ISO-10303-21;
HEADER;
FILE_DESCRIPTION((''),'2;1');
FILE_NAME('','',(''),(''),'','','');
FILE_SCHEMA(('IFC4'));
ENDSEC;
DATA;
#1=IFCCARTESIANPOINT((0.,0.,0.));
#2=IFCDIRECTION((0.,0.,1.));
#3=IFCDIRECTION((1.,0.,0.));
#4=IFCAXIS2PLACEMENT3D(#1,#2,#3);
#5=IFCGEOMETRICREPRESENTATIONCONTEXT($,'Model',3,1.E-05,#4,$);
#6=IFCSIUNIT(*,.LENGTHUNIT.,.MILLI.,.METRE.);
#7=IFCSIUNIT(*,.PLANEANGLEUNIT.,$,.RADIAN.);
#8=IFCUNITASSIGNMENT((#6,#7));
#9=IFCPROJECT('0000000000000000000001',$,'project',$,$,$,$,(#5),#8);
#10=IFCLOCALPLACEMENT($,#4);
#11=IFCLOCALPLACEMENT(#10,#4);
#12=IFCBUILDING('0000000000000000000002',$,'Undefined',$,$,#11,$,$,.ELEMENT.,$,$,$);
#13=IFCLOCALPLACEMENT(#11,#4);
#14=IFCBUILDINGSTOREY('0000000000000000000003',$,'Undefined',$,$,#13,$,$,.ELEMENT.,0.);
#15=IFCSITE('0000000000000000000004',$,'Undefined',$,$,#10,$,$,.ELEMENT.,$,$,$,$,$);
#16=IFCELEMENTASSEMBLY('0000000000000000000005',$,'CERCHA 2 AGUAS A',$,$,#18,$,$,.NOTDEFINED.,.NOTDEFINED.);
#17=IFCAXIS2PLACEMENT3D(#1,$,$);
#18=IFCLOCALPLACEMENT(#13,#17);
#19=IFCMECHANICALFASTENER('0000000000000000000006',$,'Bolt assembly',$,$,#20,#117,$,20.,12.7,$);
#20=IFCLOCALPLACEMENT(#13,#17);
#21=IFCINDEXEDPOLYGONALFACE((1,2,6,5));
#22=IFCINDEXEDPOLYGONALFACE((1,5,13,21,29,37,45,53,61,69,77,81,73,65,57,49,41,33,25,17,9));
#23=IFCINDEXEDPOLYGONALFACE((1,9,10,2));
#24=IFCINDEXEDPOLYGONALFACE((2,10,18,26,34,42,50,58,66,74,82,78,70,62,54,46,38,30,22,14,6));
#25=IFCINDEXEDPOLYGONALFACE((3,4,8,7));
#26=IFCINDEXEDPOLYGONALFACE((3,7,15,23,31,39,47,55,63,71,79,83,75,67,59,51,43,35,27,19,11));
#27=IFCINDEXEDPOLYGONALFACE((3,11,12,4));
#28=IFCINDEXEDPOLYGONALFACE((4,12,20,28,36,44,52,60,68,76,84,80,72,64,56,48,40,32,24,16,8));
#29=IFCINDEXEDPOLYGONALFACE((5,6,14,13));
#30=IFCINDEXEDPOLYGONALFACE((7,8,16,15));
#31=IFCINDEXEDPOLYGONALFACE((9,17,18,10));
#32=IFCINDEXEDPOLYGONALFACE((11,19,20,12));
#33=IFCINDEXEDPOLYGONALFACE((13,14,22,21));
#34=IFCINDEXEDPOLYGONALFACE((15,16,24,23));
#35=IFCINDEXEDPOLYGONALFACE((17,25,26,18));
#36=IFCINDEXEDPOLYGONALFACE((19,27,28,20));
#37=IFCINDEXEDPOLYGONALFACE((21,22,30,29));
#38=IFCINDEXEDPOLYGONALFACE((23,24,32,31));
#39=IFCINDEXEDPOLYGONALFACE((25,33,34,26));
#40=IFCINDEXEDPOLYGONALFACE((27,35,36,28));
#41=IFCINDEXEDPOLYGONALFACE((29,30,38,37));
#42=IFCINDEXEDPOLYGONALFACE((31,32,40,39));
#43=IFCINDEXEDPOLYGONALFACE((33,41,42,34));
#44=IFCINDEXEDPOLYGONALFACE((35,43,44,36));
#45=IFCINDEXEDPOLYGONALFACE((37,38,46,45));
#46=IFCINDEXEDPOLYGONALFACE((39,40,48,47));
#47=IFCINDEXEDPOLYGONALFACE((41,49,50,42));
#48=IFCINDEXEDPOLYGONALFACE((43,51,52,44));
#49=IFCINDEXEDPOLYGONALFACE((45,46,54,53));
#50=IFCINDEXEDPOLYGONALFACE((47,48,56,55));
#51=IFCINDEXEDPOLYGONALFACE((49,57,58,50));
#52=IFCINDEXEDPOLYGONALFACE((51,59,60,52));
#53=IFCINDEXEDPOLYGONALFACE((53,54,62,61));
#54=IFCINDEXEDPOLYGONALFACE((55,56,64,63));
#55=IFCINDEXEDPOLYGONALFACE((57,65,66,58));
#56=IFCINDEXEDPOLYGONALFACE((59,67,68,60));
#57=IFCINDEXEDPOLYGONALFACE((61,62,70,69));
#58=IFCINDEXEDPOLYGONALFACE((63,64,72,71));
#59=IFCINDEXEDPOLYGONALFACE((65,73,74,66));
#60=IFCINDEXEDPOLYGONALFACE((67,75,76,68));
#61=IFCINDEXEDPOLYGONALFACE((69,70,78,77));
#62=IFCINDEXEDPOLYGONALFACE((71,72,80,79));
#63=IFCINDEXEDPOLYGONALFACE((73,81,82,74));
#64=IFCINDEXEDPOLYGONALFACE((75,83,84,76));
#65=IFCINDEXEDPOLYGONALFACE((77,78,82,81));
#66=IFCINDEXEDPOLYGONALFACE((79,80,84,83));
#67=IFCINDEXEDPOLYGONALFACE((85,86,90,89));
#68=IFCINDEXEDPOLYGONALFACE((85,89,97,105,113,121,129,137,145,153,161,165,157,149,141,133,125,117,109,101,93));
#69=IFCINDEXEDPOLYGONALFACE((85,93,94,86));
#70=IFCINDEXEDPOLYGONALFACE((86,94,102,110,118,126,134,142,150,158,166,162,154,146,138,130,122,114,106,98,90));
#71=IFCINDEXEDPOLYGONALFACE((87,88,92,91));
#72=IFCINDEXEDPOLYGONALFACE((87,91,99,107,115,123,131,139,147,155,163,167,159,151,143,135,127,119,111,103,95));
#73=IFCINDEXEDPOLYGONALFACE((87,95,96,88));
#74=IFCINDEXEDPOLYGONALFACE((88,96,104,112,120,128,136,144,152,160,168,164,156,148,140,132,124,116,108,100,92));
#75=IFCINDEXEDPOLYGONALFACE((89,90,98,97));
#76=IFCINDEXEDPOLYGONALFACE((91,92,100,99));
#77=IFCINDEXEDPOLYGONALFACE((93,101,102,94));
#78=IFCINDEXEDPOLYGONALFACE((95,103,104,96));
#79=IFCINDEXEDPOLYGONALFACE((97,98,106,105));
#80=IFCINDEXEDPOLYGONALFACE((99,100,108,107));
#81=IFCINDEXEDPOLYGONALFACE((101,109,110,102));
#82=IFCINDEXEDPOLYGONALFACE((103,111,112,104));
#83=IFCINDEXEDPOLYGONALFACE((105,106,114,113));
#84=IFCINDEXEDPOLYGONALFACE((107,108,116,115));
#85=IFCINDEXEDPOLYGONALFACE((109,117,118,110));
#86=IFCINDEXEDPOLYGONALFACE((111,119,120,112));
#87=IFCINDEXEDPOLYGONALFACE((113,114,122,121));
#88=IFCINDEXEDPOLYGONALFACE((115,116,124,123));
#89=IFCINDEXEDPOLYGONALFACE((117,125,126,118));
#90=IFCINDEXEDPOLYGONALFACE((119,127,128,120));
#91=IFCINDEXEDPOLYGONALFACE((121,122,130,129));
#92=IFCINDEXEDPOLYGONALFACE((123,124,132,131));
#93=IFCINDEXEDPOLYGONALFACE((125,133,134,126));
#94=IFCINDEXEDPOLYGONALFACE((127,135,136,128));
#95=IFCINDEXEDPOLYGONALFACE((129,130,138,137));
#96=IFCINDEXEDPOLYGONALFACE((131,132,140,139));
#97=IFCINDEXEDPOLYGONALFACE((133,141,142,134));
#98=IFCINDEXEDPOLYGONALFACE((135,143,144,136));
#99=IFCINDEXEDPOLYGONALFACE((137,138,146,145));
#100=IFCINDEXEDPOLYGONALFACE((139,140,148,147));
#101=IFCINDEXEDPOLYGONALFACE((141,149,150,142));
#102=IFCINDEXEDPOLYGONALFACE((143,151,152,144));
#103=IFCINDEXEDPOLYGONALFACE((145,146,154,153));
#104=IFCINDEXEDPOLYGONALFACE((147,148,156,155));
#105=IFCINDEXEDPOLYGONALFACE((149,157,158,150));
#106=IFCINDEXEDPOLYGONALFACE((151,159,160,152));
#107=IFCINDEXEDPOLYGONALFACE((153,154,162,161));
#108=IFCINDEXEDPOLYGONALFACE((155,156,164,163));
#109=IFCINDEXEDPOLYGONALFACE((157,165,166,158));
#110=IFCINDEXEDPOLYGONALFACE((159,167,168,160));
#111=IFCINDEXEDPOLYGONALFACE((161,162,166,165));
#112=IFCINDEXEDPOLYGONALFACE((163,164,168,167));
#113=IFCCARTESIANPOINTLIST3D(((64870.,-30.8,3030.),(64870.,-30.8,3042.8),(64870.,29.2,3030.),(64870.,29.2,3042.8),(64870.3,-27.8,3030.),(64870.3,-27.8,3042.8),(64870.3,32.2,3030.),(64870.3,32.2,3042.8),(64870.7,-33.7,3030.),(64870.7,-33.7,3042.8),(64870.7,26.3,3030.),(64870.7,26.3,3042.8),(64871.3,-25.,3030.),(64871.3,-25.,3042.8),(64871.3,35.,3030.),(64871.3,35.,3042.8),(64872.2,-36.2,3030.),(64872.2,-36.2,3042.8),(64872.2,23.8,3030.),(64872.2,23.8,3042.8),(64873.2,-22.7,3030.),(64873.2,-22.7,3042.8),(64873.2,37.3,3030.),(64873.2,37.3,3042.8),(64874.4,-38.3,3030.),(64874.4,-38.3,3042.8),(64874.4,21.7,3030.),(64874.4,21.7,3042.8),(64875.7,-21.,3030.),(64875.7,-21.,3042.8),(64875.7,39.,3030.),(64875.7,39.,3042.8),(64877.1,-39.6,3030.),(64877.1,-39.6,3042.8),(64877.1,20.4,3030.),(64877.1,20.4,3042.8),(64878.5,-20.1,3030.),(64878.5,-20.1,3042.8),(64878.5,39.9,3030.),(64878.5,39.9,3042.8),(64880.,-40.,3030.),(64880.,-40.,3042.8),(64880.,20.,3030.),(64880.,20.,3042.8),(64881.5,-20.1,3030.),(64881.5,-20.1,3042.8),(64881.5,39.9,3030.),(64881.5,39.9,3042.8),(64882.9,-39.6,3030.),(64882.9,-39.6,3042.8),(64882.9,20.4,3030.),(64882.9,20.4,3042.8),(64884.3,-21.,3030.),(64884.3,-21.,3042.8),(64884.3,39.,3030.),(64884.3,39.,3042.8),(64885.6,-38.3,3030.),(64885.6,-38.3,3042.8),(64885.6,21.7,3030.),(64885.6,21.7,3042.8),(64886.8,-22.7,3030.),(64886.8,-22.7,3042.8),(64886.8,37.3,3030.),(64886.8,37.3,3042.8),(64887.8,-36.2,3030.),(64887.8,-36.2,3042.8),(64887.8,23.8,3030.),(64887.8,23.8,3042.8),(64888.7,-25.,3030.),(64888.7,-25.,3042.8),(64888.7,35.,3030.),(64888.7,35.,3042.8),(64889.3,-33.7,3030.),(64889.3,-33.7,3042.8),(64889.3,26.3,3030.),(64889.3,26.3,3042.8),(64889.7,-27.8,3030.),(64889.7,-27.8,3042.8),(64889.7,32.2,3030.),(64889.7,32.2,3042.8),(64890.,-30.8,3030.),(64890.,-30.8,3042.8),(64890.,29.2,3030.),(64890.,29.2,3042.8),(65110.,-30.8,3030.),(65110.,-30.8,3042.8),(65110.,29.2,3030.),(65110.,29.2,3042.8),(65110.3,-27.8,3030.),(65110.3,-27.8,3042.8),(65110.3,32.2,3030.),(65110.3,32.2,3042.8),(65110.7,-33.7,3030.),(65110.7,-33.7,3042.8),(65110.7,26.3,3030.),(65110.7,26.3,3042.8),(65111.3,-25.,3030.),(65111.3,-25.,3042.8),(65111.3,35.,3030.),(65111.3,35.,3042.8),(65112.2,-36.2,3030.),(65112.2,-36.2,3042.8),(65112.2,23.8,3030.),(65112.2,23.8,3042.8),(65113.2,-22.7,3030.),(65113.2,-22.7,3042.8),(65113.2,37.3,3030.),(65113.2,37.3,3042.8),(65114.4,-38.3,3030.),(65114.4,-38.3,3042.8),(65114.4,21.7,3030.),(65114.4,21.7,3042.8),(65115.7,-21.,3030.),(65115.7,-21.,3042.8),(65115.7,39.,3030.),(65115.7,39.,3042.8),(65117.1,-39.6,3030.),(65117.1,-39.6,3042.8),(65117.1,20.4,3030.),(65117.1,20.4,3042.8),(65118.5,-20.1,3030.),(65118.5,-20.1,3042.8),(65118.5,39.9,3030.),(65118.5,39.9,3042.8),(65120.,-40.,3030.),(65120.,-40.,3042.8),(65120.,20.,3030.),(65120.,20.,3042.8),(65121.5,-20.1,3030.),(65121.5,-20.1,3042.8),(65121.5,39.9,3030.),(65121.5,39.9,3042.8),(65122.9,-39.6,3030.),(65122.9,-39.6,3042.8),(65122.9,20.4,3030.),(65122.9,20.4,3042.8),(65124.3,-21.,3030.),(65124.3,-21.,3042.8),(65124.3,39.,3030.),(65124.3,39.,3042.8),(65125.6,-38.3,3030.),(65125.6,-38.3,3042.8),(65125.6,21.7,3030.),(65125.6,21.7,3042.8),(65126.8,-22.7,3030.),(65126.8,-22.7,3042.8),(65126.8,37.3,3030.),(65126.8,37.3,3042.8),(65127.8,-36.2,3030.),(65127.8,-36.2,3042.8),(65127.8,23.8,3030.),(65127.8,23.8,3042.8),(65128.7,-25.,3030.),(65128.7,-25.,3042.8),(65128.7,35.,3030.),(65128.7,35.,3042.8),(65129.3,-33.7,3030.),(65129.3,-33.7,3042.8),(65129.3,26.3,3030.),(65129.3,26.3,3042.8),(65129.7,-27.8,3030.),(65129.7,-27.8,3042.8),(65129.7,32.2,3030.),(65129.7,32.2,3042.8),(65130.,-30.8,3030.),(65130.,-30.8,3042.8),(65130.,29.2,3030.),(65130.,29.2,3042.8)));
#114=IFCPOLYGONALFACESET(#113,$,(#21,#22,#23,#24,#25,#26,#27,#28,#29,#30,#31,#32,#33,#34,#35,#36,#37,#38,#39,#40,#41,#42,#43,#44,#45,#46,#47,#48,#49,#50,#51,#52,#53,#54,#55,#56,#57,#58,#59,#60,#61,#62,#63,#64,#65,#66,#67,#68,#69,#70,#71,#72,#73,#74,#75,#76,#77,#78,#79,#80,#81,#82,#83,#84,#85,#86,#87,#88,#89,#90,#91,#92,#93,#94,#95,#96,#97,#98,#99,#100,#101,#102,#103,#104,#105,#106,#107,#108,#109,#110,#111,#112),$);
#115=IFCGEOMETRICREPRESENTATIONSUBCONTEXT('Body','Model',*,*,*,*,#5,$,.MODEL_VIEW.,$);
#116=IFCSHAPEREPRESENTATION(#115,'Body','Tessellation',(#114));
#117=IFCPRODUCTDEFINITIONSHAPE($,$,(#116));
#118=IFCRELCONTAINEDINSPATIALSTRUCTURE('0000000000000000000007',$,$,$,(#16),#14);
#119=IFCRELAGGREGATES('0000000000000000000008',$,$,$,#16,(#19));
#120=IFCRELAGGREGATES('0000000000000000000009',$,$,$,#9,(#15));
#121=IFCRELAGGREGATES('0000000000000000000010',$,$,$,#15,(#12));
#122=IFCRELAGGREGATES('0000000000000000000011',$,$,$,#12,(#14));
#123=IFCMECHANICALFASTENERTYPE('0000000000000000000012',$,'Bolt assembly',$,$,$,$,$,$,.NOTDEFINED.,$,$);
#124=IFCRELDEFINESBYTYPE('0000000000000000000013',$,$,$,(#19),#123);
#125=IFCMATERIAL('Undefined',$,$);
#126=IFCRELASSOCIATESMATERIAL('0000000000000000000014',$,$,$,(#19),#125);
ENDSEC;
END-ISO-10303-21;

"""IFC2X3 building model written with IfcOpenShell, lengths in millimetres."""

from ifc_helpers import new_model, si_unit, frame, origin_with_axes, origin_2d_with_axis, place, context, subcontext, project, spatial, circle, extrude, source, transform, mapped, material, type_object, element, aggregate, save


model = new_model("IFC2X3")

# Units and contexts
model_context = context("Model", 3, precision=1e-05, world=origin_with_axes())
body_context = subcontext(model_context, "Body", "Model", "MODEL_VIEW")
ifc_project = project(units=[si_unit("LENGTHUNIT", "METRE", prefix="MILLI"), si_unit("PLANEANGLEUNIT", "RADIAN")], contexts=[model_context])

# Site, building, storey
site_placement = place(None, origin_with_axes())
site = spatial("IfcSite", under=ifc_project, at=site_placement, Name="Undefined", CompositionType="ELEMENT")
building_placement = place(site_placement, origin_with_axes())
building = spatial("IfcBuilding", under=site, at=building_placement, Name="Undefined", CompositionType="ELEMENT")
storey_placement = place(building_placement, origin_with_axes())
storey = spatial("IfcBuildingStorey", under=building, at=storey_placement, Name="Undefined", CompositionType="ELEMENT", Elevation=0.0)

# Element assembly
assembly_1_placement = place(storey_placement, origin_with_axes())
assembly_1 = element("IfcElementAssembly", 1, at=assembly_1_placement, inside=storey, Name="CERCHA 2 AGUAS A", AssemblyPlace="NOTDEFINED", PredefinedType="NOTDEFINED")

# Shared definitions
ifc_material_1 = material(Name="Undefined")
mechanical_fastener_type = type_object("IfcMechanicalFastenerType", Name="Bolt assembly")

# Mechanical fastener
shared_shape_1 = source(origin_with_axes(), body_context, "Body", "SweptSolid", [
    extrude(circle(Radius=10.0, at=origin_2d_with_axis()), frame((0.0, -12.7, 0.0), z_axis=(0.0, 1.0, 0.0), x_axis=(1.0, 0.0, 0.0)), (0.0, 0.0, 1.0), 12.8),
])
mechanical_fastener_1_placement = place(assembly_1_placement, frame((65000.0, 30.0, 3042.7), z_axis=(-1.0, 0.0, 0.0), x_axis=(0.0, -1.0, 0.0)))
mechanical_fastener_1 = element("IfcMechanicalFastener", 2, at=mechanical_fastener_1_placement, type_object=mechanical_fastener_type, material=ifc_material_1, Name="Bolt assembly", NominalDiameter=20.0, NominalLength=12.7, context=body_context, shape_type="MappedRepresentation", body=[
    mapped(shared_shape_1, transform((0.0, 0.0, -120.0))),
    mapped(shared_shape_1, transform((60.0, 0.0, -120.0))),
    mapped(shared_shape_1, transform((0.0, 0.0, 120.0))),
    mapped(shared_shape_1, transform((60.0, 0.0, 120.0))),
])
aggregate(assembly_1, [mechanical_fastener_1])

save(model, "model.ifc")
